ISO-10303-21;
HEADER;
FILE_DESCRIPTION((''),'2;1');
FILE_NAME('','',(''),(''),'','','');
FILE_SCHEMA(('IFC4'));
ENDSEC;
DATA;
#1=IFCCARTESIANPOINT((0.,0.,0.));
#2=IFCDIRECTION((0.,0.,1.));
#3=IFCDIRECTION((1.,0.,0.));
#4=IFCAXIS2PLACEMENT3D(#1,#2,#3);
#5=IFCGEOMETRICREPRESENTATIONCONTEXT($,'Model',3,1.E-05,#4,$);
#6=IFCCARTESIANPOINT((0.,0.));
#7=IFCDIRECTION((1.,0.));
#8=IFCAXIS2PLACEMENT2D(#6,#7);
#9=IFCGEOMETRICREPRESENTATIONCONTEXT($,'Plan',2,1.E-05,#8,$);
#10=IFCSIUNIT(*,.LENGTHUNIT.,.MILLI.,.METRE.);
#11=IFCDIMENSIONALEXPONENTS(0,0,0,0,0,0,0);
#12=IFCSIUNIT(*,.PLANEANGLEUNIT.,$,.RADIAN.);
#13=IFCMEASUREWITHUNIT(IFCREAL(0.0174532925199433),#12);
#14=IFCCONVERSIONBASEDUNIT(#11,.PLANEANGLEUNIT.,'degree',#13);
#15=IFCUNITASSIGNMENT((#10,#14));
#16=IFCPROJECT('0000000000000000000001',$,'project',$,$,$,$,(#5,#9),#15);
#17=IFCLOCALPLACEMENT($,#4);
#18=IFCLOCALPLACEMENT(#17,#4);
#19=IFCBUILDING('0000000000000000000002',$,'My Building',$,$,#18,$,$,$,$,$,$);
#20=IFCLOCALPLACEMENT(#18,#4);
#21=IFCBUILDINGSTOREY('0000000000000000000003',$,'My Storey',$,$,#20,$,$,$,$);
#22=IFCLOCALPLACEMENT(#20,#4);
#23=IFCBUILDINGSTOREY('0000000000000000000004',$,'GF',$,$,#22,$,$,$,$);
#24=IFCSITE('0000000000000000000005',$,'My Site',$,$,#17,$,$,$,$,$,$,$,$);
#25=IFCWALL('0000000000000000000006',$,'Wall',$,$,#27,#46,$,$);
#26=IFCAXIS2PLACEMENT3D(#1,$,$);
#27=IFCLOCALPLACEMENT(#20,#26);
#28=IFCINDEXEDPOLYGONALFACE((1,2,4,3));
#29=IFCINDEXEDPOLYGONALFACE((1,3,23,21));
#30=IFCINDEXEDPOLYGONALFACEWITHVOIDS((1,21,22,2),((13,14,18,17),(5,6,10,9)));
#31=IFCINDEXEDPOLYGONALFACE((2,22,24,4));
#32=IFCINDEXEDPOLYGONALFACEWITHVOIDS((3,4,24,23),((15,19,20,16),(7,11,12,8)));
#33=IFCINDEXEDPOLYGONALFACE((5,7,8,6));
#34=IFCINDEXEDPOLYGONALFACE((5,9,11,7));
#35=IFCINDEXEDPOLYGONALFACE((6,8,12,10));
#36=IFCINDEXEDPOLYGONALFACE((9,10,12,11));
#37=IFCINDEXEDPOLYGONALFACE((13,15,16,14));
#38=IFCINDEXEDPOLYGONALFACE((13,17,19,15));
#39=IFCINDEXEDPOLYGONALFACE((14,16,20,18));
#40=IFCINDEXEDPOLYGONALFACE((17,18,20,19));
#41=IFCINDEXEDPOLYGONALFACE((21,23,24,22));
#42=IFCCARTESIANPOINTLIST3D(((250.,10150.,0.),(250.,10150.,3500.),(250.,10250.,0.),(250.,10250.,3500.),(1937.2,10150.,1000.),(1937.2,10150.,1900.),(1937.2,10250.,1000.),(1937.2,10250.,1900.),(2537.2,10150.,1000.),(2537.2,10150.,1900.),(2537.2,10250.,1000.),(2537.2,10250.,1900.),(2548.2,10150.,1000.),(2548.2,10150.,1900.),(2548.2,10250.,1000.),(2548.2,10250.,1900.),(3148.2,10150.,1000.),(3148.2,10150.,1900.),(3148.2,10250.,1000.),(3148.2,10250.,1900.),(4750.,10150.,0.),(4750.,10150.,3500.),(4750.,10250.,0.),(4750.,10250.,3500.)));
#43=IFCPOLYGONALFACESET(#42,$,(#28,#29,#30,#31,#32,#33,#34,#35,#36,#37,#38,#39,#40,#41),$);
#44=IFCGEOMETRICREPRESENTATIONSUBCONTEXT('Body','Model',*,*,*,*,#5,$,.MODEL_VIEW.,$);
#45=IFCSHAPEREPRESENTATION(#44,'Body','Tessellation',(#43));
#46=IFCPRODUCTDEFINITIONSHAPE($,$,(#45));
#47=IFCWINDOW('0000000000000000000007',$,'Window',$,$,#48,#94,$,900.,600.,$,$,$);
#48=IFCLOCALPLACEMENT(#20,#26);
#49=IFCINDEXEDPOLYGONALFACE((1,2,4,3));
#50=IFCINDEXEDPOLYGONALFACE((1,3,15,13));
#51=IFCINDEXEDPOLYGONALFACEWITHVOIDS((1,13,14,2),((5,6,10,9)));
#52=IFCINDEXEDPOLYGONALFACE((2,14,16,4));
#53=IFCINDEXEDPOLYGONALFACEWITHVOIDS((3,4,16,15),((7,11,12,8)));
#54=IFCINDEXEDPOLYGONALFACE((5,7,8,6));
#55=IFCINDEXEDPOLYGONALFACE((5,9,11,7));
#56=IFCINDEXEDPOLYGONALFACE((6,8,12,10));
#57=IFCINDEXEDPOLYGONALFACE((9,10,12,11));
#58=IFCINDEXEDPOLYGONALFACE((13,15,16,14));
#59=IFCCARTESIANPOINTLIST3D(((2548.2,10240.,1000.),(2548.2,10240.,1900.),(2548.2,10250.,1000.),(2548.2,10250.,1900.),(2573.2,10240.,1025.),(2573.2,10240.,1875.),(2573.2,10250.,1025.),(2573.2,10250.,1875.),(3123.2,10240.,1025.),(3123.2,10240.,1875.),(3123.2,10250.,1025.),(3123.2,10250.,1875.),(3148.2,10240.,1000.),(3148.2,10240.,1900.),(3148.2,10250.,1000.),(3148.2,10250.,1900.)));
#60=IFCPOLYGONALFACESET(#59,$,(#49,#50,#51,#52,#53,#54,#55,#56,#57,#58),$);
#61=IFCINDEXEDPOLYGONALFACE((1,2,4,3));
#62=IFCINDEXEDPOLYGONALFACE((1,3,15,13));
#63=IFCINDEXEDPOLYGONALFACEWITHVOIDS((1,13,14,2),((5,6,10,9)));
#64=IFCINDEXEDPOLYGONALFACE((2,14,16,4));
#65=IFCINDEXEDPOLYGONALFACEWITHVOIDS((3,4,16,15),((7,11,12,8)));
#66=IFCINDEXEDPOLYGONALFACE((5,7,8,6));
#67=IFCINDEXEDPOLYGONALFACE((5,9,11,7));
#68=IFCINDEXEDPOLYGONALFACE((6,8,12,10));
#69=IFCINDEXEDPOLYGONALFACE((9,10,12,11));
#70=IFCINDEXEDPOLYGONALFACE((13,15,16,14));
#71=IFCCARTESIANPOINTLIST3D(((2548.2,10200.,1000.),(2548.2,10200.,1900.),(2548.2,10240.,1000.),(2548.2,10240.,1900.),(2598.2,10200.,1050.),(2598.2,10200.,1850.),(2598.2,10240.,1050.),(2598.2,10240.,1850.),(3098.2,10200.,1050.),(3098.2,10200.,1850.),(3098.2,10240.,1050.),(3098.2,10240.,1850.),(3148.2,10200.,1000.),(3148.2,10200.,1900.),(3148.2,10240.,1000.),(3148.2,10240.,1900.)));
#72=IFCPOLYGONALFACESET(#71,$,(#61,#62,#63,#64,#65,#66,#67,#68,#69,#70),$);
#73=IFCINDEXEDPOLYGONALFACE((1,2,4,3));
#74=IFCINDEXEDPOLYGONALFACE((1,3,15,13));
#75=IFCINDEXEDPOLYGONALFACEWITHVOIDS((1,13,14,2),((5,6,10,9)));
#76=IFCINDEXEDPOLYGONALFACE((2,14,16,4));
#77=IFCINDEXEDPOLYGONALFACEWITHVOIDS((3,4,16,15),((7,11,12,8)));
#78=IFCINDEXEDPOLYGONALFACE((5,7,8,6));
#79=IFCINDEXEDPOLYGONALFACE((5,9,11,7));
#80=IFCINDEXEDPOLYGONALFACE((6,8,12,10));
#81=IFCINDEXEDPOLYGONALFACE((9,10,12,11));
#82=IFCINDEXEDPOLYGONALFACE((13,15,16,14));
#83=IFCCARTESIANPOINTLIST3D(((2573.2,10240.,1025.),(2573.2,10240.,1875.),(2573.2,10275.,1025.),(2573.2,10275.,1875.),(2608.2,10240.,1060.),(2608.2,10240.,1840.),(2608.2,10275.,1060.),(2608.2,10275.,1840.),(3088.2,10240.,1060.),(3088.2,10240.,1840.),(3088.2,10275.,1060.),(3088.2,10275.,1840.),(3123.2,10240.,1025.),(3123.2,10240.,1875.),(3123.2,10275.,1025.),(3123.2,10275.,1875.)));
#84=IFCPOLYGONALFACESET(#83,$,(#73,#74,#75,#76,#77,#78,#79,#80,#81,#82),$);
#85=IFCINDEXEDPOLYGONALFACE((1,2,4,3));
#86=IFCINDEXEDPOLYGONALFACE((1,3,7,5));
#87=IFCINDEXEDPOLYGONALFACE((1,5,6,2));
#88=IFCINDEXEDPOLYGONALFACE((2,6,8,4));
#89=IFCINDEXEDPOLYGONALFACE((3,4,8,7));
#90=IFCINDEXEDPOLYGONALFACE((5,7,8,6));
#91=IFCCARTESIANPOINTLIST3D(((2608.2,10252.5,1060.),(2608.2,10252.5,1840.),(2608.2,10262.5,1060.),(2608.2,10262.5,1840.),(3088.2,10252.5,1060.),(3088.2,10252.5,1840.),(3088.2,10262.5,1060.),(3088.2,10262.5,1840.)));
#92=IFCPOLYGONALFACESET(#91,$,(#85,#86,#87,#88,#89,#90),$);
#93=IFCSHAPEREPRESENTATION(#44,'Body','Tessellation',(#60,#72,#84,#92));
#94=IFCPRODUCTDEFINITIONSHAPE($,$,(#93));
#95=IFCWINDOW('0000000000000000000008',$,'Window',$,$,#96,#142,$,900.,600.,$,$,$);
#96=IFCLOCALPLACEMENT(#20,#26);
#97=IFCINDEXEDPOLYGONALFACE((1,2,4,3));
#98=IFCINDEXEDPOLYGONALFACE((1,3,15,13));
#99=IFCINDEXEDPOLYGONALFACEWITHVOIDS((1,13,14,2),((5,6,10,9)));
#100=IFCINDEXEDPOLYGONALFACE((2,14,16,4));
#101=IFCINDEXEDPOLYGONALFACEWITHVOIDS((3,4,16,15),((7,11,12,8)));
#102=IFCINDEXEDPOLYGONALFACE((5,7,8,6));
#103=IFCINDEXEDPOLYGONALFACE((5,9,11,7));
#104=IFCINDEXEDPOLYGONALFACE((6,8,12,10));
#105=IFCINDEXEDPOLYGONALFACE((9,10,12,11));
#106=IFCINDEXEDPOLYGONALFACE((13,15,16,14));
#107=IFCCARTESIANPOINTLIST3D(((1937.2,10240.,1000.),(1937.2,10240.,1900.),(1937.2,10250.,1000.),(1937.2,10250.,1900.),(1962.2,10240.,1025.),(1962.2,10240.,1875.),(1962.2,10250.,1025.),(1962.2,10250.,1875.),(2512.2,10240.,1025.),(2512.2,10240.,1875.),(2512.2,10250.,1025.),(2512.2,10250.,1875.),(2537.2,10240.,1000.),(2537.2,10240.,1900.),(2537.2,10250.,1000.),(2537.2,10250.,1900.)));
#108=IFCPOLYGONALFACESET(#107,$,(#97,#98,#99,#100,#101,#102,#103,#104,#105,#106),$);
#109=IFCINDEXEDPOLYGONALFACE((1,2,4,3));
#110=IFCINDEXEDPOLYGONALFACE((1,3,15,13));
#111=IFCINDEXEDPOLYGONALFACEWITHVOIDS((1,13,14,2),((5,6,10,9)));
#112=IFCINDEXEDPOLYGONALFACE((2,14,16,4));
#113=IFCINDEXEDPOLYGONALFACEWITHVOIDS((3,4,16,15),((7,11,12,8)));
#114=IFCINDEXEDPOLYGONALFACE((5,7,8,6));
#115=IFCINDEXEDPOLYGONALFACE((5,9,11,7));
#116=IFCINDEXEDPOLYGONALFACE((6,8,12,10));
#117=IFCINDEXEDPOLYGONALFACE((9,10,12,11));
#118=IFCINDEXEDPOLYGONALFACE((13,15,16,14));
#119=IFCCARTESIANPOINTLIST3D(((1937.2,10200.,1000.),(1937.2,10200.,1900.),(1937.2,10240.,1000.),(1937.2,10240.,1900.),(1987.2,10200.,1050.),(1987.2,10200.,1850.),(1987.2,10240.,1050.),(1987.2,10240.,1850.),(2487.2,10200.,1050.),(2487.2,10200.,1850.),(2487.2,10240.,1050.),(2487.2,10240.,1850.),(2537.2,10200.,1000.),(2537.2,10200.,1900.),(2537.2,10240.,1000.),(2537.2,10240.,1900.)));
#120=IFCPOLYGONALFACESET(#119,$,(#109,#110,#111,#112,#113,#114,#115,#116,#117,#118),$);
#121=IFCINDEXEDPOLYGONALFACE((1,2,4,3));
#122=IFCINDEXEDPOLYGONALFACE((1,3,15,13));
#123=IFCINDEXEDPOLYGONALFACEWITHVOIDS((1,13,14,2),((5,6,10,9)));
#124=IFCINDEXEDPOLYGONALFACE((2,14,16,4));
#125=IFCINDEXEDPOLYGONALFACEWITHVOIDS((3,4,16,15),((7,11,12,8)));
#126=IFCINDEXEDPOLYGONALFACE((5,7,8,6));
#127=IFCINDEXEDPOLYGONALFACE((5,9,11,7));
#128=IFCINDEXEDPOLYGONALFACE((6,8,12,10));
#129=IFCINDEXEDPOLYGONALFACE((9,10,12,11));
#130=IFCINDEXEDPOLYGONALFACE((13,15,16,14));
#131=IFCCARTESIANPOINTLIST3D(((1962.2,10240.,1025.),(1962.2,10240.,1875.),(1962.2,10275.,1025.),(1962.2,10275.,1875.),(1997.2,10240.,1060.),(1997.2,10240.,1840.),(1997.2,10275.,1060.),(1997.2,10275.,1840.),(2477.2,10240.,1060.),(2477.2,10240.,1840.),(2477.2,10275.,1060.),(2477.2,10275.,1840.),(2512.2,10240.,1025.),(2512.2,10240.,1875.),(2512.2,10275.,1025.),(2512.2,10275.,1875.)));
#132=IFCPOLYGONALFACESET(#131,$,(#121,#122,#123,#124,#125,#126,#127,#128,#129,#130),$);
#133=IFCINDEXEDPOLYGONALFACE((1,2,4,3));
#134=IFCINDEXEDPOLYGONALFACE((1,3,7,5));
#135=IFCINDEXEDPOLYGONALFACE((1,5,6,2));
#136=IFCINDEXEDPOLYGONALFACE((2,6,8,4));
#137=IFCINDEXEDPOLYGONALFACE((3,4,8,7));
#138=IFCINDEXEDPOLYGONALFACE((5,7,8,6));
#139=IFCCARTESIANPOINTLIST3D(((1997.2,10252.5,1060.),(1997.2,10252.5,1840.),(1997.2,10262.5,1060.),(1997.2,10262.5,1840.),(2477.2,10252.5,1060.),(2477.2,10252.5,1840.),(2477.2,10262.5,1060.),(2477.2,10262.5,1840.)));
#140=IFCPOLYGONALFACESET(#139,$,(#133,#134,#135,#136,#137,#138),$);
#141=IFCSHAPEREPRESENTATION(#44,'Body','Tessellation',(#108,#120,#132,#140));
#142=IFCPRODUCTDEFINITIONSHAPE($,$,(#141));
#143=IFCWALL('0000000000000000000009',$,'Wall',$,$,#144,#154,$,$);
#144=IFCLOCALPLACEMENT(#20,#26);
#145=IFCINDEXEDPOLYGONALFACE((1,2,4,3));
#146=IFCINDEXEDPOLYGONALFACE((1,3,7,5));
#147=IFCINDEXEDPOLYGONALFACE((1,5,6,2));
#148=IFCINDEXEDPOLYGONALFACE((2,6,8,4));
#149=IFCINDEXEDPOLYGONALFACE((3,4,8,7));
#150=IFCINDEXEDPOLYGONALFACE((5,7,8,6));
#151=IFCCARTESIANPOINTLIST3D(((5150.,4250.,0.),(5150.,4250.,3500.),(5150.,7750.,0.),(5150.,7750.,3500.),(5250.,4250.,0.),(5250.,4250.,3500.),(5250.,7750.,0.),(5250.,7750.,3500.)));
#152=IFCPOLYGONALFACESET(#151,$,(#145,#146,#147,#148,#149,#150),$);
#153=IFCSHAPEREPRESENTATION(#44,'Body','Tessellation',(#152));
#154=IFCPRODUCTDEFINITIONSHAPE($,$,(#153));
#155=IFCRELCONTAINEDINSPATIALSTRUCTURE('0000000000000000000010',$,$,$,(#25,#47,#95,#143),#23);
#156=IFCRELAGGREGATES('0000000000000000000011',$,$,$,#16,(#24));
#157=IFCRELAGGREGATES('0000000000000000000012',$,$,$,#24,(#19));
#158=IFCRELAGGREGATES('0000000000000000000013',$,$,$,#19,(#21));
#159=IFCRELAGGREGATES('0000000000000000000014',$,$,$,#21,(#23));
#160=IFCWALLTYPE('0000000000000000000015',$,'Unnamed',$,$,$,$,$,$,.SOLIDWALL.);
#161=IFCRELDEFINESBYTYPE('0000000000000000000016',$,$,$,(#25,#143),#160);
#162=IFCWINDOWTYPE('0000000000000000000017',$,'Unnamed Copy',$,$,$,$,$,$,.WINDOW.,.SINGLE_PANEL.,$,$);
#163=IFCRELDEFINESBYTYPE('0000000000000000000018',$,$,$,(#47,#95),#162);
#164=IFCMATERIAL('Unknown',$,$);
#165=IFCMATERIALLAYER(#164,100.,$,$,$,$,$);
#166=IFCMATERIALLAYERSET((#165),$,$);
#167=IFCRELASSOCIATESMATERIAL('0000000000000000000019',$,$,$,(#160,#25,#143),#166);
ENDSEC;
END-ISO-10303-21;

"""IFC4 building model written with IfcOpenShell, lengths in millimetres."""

from ifc_helpers import new_model, entity, si_unit, converted_unit, frame, origin_with_axes, origin_2d_with_axis, place, context, subcontext, project, spatial, line, indexed_curve, outline, extrude, shape, source, transform, mapped, material, layer, layer_set, layer_usage, type_object, type_shapes, element, fill, save


model = new_model("IFC4")

# Units and contexts
model_context = context("Model", 3, precision=1e-05, world=origin_with_axes())
plan_context = context("Plan", 2, precision=1e-05, world=origin_2d_with_axis())
body_context_1 = subcontext(model_context, "Body", "Model", "MODEL_VIEW")
body_context_2 = subcontext(plan_context, "Body", "Plan", "PLAN_VIEW")
ifc_project = project(units=[si_unit("LENGTHUNIT", "METRE", prefix="MILLI"), converted_unit("PLANEANGLEUNIT", "degree", entity("IfcReal", 0.0174532925199433), si_unit("PLANEANGLEUNIT", "RADIAN"), dimensions=[0, 0, 0, 0, 0, 0, 0])], contexts=[model_context, plan_context])

# Site, building, storeys
site_placement = place(None, origin_with_axes())
site = spatial("IfcSite", under=ifc_project, at=site_placement, Name="My Site")
building_placement = place(site_placement, origin_with_axes())
building = spatial("IfcBuilding", under=site, at=building_placement, Name="My Building")
storey_1_placement = place(building_placement, origin_with_axes())
storey_1 = spatial("IfcBuildingStorey", under=building, at=storey_1_placement, Name="My Storey")
storey_2_placement = place(storey_1_placement, origin_with_axes())
storey_2 = spatial("IfcBuildingStorey", under=storey_1, at=storey_2_placement, Name="GF")

# Shared definitions
ifc_material = material(Name="Unknown")
ifc_layer_1 = layer(ifc_material, 100.0)
ifc_layer_set_1 = layer_set([ifc_layer_1])
wall_type_1 = type_object("IfcWallType", Name="Unnamed", PredefinedType="SOLIDWALL", material=ifc_layer_set_1)

# Wall, openings, windows
ifc_layer_usage_1 = layer_usage(ifc_layer_set_1, "AXIS2", "POSITIVE", 0.0)
wall_1_placement = place(storey_2_placement, frame((250.0, 10150.0, 0.0), z_axis=(0.0, 0.0, 1.0), x_axis=(1.0, 0.0, 0.0)))
wall_1 = element("IfcWall", 1, at=wall_1_placement, inside=storey_2, type_object=wall_type_1, material=ifc_layer_usage_1, Name="Wall", context=body_context_1, shape_type="SweptSolid", body=[
    extrude(outline(indexed_curve([(0.0, 0.0), (0.0, 100.0), (4500.0, 100.0), (4500.0, 0.0)], segments=[line(1, 2, 3, 4, 1)])), origin_with_axes(), (0.0, 0.0, 1.0), 3500.0),
])
shared_shape_1 = source(origin_with_axes(), body_context_1, "Body", "SweptSolid", [
    extrude(outline(indexed_curve([(0.0, 0.0), (600.0, 0.0), (600.0, 900.0), (0.0, 900.0)], segments=[line(1, 2, 3, 4, 1)])), frame((0.0, -600.0, 0.0), z_axis=(0.0, -1.0, 0.0), x_axis=(1.0, 0.0, 0.0)), (0.0, 0.0, -1.0), 1200.0),
])
opening_1_placement = place(wall_1_placement, frame((2298.2, 0.0, 1000.0), z_axis=(0.0, 0.0, 1.0), x_axis=(1.0, 0.0, 0.0)))
opening_1 = element("IfcOpeningElement", 2, at=opening_1_placement, cuts=wall_1, PredefinedType="OPENING", context=body_context_1, shape_type="MappedRepresentation", body=[
    mapped(shared_shape_1, transform((0.0, 0.0, 0.0), x_axis=(1.0, 0.0, 0.0), y_axis=(0.0, 1.0, 0.0), z_axis=(0.0, 0.0, 1.0), scale=1.0)),
])
opening_2_placement = place(wall_1_placement, frame((1687.2, 0.0, 1000.0), z_axis=(0.0, 0.0, 1.0), x_axis=(1.0, 0.0, 0.0)))
opening_2 = element("IfcOpeningElement", 3, at=opening_2_placement, cuts=wall_1, PredefinedType="OPENING", context=body_context_1, shape_type="MappedRepresentation", body=[
    mapped(shared_shape_1, transform((0.0, 0.0, 0.0), x_axis=(1.0, 0.0, 0.0), y_axis=(0.0, 1.0, 0.0), z_axis=(0.0, 0.0, 1.0), scale=1.0)),
])
window_type_1 = type_object("IfcWindowType", Name="Unnamed Copy", PartitioningType="SINGLE_PANEL", PredefinedType="WINDOW")
shared_shape_2 = source(origin_with_axes(), body_context_1, "Body", "SweptSolid", [
    extrude(outline(indexed_curve([(0.0, 0.0), (600.0, 0.0), (600.0, 900.0), (0.0, 900.0)], segments=[line(1, 2, 3, 4, 1)]), holes=[indexed_curve([(25.0, 25.0), (575.0, 25.0), (575.0, 875.0), (25.0, 875.0)], segments=[line(1, 2, 3, 4, 1)])]), frame((0.0, 90.0, 0.0), z_axis=(0.0, -1.0, 0.0), x_axis=(1.0, 0.0, 0.0)), (0.0, 0.0, -1.0), 10.0),
    extrude(outline(indexed_curve([(0.0, 0.0), (600.0, 0.0), (600.0, 900.0), (0.0, 900.0)], segments=[line(1, 2, 3, 4, 1)]), holes=[indexed_curve([(50.0, 50.0), (550.0, 50.0), (550.0, 850.0), (50.0, 850.0)], segments=[line(1, 2, 3, 4, 1)])]), frame((0.0, 50.0, 0.0), z_axis=(0.0, -1.0, 0.0), x_axis=(1.0, 0.0, 0.0)), (0.0, 0.0, -1.0), 40.0),
    extrude(outline(indexed_curve([(0.0, 0.0), (550.0, 0.0), (550.0, 850.0), (0.0, 850.0)], segments=[line(1, 2, 3, 4, 1)]), holes=[indexed_curve([(35.0, 35.0), (515.0, 35.0), (515.0, 815.0), (35.0, 815.0)], segments=[line(1, 2, 3, 4, 1)])]), frame((25.0, 90.0, 25.0), z_axis=(0.0, -1.0, 0.0), x_axis=(1.0, 0.0, 0.0)), (0.0, 0.0, -1.0), 35.0),
    extrude(outline(indexed_curve([(35.0, 35.0), (515.0, 35.0), (515.0, 815.0), (35.0, 815.0)], segments=[line(1, 2, 3, 4, 1)])), frame((25.0, 102.5, 25.0), z_axis=(0.0, -1.0, 0.0), x_axis=(1.0, 0.0, 0.0)), (0.0, 0.0, -1.0), 10.0),
])
shared_shape_3 = source(origin_with_axes(), body_context_2, "Body", "Curve2D", [
    entity("IfcIndexedPolyCurve", entity("IfcCartesianPointList2D", [[50.0, 50.0], [550.0, 50.0]])),
    entity("IfcIndexedPolyCurve", entity("IfcCartesianPointList2D", [[0.0, 100.0], [25.0, 100.0], [25.0, 90.0], [50.0, 90.0], [50.0, 50.0], [0.0, 50.0]]), [entity("IfcLineIndex", [1, 2, 3, 4, 5, 6, 1])]),
    entity("IfcIndexedPolyCurve", entity("IfcCartesianPointList2D", [[600.0, 100.0], [575.0, 100.0], [575.0, 90.0], [550.0, 90.0], [550.0, 50.0], [600.0, 50.0]]), [entity("IfcLineIndex", [1, 2, 3, 4, 5, 6, 1])]),
    entity("IfcIndexedPolyCurve", entity("IfcCartesianPointList2D", [[25.0, 90.0], [60.0, 90.0], [60.0, 125.0], [25.0, 125.0]]), [entity("IfcLineIndex", [1, 2, 3, 4, 1])]),
    entity("IfcIndexedPolyCurve", entity("IfcCartesianPointList2D", [[575.0, 90.0], [540.0, 90.0], [540.0, 125.0], [575.0, 125.0]]), [entity("IfcLineIndex", [1, 2, 3, 4, 1])]),
    entity("IfcIndexedPolyCurve", entity("IfcCartesianPointList2D", [[60.0, 90.0], [540.0, 90.0]])),
    entity("IfcIndexedPolyCurve", entity("IfcCartesianPointList2D", [[60.0, 125.0], [540.0, 125.0]])),
    entity("IfcIndexedPolyCurve", entity("IfcCartesianPointList2D", [[60.0, 107.5], [540.0, 107.5]])),
])
type_shapes(window_type_1, [shared_shape_2, shared_shape_3])
window_1_placement = place(opening_1_placement, origin_with_axes())
window_1 = element("IfcWindow", 4, at=window_1_placement, inside=storey_2, type_object=window_type_1, Name="Window", OverallHeight=900.0, OverallWidth=600.0, shapes=[
    shape(body_context_1, "Body", "MappedRepresentation", [mapped(shared_shape_2, transform((0.0, 0.0, 0.0), x_axis=(1.0, 0.0, 0.0), y_axis=(0.0, 1.0, 0.0), z_axis=(0.0, 0.0, 1.0), scale=1.0))]),
    shape(body_context_2, "Body", "MappedRepresentation", [mapped(shared_shape_3, transform((0.0, 0.0, 0.0), x_axis=(1.0, 0.0, 0.0), y_axis=(0.0, 1.0, 0.0), z_axis=(0.0, 0.0, 1.0), scale=1.0))]),
])
fill(opening_1, window_1)
window_2_placement = place(opening_2_placement, origin_with_axes())
window_2 = element("IfcWindow", 5, at=window_2_placement, inside=storey_2, type_object=window_type_1, Name="Window", OverallHeight=900.0, OverallWidth=600.0, shapes=[
    shape(body_context_1, "Body", "MappedRepresentation", [mapped(shared_shape_2, transform((0.0, 0.0, 0.0), x_axis=(1.0, 0.0, 0.0), y_axis=(0.0, 1.0, 0.0), z_axis=(0.0, 0.0, 1.0), scale=1.0))]),
    shape(body_context_2, "Body", "MappedRepresentation", [mapped(shared_shape_3, transform((0.0, 0.0, 0.0), x_axis=(1.0, 0.0, 0.0), y_axis=(0.0, 1.0, 0.0), z_axis=(0.0, 0.0, 1.0), scale=1.0))]),
])
fill(opening_2, window_2)

# Wall
ifc_layer_usage_2 = layer_usage(ifc_layer_set_1, "AXIS2", "POSITIVE", 0.0)
wall_2_placement = place(storey_2_placement, frame((5150.0, 7750.0, 0.0), z_axis=(0.0, 0.0, 1.0), x_axis=(0.0, -1.0, 0.0)))
element("IfcWall", 6, at=wall_2_placement, inside=storey_2, type_object=wall_type_1, material=ifc_layer_usage_2, Name="Wall", context=body_context_1, shape_type="SweptSolid", body=[
    extrude(outline(indexed_curve([(0.0, 0.0), (0.0, 100.0), (3500.0, 100.0), (3500.0, 0.0)], segments=[line(1, 2, 3, 4, 1)])), origin_with_axes(), (0.0, 0.0, 1.0), 3500.0),
])

save(model, "model.ifc")
